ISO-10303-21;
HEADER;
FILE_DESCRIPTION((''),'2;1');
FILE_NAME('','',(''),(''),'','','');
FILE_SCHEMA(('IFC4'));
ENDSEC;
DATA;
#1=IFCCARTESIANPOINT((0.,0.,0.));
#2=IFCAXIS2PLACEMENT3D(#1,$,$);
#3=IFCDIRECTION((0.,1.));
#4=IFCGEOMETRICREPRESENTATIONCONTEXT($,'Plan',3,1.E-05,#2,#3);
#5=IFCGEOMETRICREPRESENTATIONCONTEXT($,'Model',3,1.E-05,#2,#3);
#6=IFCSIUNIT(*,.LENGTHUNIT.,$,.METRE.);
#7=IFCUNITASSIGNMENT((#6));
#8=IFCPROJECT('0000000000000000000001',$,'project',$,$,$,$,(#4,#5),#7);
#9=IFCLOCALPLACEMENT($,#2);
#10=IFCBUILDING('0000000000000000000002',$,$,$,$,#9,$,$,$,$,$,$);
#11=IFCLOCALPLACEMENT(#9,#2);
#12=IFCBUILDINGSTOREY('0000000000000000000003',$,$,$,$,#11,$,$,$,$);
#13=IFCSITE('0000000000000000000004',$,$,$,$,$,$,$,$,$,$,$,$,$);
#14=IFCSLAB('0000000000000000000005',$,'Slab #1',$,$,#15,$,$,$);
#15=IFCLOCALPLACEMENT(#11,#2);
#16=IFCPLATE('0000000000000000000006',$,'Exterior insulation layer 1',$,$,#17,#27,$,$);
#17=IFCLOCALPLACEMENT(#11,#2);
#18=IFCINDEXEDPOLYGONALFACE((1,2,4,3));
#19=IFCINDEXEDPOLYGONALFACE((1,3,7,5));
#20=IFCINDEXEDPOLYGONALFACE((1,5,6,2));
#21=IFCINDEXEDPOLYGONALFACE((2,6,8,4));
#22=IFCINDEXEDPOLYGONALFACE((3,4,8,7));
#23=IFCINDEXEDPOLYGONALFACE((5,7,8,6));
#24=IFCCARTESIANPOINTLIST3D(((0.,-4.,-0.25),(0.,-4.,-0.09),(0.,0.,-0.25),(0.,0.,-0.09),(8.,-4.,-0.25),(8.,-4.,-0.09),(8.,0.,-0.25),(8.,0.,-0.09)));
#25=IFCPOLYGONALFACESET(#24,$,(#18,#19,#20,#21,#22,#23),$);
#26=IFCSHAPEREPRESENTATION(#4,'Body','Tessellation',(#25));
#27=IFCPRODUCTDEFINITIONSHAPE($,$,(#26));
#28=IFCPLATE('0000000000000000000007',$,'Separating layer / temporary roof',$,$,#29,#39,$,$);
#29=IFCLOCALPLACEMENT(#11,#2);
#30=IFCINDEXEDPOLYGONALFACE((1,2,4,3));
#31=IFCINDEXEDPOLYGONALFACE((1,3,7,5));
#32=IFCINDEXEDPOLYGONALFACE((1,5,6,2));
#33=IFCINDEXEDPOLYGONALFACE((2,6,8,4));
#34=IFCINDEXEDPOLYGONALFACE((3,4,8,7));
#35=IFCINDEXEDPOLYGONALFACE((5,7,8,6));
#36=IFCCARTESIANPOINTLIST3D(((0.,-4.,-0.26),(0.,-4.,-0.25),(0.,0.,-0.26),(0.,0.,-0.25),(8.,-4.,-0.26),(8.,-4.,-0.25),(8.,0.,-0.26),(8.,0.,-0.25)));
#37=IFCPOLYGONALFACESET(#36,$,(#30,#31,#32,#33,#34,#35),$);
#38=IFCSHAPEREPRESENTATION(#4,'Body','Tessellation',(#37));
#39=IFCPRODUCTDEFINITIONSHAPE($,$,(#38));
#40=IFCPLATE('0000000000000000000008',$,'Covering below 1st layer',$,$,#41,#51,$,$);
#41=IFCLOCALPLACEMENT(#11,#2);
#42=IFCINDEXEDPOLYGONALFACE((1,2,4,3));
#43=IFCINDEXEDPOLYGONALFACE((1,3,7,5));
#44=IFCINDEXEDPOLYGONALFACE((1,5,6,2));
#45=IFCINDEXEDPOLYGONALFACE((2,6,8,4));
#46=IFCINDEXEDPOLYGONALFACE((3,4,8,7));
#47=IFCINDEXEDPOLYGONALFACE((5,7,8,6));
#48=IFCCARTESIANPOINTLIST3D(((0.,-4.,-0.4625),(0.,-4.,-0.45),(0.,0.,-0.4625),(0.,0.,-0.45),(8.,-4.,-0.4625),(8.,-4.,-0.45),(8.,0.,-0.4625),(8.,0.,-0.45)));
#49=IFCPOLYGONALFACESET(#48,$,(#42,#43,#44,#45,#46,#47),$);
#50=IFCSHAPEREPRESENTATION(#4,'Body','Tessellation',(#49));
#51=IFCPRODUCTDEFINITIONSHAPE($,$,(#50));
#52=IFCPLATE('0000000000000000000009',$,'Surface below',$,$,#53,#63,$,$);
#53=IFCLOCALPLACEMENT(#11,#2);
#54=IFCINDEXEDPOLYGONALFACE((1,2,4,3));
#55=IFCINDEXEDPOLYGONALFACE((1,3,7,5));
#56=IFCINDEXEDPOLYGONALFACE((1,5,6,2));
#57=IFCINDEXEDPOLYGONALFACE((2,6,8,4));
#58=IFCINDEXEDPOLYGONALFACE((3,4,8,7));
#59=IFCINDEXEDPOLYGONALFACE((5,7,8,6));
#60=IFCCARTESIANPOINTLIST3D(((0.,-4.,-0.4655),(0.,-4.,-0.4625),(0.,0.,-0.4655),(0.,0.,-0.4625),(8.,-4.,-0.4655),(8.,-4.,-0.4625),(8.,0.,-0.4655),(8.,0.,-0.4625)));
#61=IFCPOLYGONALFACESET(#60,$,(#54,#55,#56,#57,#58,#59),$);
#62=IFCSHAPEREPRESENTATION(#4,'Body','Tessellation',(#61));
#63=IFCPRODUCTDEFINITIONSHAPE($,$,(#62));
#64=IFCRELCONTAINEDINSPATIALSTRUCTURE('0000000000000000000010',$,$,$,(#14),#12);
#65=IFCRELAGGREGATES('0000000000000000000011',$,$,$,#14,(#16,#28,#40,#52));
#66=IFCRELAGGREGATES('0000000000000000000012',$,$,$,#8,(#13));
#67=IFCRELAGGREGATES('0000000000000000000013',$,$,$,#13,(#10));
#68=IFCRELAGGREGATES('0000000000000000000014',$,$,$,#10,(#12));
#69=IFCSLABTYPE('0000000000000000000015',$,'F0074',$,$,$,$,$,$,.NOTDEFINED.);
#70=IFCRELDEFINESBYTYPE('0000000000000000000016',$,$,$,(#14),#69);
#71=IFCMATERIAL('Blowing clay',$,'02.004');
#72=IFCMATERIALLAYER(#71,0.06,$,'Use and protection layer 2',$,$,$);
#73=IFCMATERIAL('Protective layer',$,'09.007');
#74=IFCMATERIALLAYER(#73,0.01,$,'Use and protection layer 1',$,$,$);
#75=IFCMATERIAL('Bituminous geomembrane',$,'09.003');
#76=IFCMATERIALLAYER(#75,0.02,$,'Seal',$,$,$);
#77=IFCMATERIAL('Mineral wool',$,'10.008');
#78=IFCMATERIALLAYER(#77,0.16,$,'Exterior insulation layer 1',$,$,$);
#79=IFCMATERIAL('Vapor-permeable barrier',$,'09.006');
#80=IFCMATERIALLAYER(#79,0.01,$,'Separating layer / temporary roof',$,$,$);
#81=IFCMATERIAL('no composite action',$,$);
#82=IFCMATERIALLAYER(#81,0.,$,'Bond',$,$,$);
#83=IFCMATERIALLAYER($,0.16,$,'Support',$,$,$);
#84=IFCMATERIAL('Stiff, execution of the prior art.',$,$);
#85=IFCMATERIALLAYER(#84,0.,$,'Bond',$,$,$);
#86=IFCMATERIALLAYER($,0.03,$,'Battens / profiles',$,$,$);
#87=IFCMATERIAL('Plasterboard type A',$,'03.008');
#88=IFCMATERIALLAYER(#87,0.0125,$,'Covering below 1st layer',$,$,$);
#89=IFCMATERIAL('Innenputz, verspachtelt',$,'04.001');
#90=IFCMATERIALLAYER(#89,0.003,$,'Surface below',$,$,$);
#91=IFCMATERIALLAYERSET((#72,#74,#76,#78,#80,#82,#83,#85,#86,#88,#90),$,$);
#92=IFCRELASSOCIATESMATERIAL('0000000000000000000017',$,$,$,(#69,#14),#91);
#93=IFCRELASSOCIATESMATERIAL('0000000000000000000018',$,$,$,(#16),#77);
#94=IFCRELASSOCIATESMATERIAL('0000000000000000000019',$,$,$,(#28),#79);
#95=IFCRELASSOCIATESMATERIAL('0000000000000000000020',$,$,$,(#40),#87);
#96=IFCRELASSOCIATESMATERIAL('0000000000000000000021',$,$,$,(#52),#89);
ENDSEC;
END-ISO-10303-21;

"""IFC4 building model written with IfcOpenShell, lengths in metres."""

from ifc_helpers import new_model, si_unit, direction, frame, frame_2d, origin, place, context, project, spatial, rectangle, extrude, material, layer, layer_set, type_object, element, aggregate, save


model = new_model("IFC4")

# Units and contexts
plan_context = context("Plan", 3, precision=1e-05, world=origin(), true_north=direction((0.0, 1.0)))
model_context = context("Model", 3, precision=1e-05, world=origin(), true_north=direction((0.0, 1.0)))
ifc_project = project(units=[si_unit("LENGTHUNIT", "METRE")], contexts=[plan_context, model_context])

# Site, building, storey
site = spatial("IfcSite", under=ifc_project)
building_placement = place(None, origin())
building = spatial("IfcBuilding", under=site, at=building_placement)
storey_placement = place(building_placement, origin())
storey = spatial("IfcBuildingStorey", under=building, at=storey_placement)

# Slab, plates
ifc_material_1 = material(Name="Blowing clay", Category="02.004")
ifc_layer_1 = layer(ifc_material_1, 0.06, Name="Use and protection layer 2")
ifc_material_2 = material(Name="Protective layer", Category="09.007")
ifc_layer_2 = layer(ifc_material_2, 0.01, Name="Use and protection layer 1")
ifc_material_3 = material(Name="Bituminous geomembrane", Category="09.003")
ifc_layer_3 = layer(ifc_material_3, 0.02, Name="Seal")
ifc_material_4 = material(Name="Mineral wool", Category="10.008")
ifc_layer_4 = layer(ifc_material_4, 0.16, Name="Exterior insulation layer 1")
ifc_material_5 = material(Name="Vapor-permeable barrier", Category="09.006")
ifc_layer_5 = layer(ifc_material_5, 0.01, Name="Separating layer / temporary roof")
ifc_material_6 = material(Name="no composite action")
ifc_layer_6 = layer(ifc_material_6, 0.0, Name="Bond")
ifc_layer_7 = layer(None, 0.16, Name="Support")
ifc_material_7 = material(Name="Stiff, execution of the prior art.")
ifc_layer_8 = layer(ifc_material_7, 0.0, Name="Bond")
ifc_layer_9 = layer(None, 0.03, Name="Battens / profiles")
ifc_material_8 = material(Name="Plasterboard type A", Category="03.008")
ifc_layer_10 = layer(ifc_material_8, 0.0125, Name="Covering below 1st layer")
ifc_material_9 = material(Name="Innenputz, verspachtelt", Category="04.001")
ifc_layer_11 = layer(ifc_material_9, 0.003, Name="Surface below")
ifc_layer_set = layer_set([ifc_layer_1, ifc_layer_2, ifc_layer_3, ifc_layer_4, ifc_layer_5, ifc_layer_6, ifc_layer_7, ifc_layer_8, ifc_layer_9, ifc_layer_10, ifc_layer_11])
slab_type = type_object("IfcSlabType", Name="F0074", PredefinedType="NOTDEFINED", material=ifc_layer_set)
slab_placement = place(None, frame((0.0, 0.0, 0.0), z_axis=(0.0, 0.0, -1.0), x_axis=(1.0, 0.0, 0.0)))
slab = element("IfcSlab", 1, at=slab_placement, inside=storey, type_object=slab_type, material=ifc_layer_set, Name="Slab #1")
plate_1_placement = place(slab_placement, origin())
plate_1 = element("IfcPlate", 2, at=plate_1_placement, material=ifc_material_4, Name="Exterior insulation layer 1", context=plan_context, shape_type="SweptSolid", body=[
    extrude(rectangle(XDim=8.0, YDim=4.0, at=frame_2d((4.0, 2.0), x_axis=(1.0, 0.0))), frame((0.0, 0.0, 0.09), z_axis=(0.0, 0.0, 1.0), x_axis=(1.0, 0.0, 0.0)), (0.0, 0.0, 1.0), 0.16),
])
plate_2_placement = place(slab_placement, origin())
plate_2 = element("IfcPlate", 3, at=plate_2_placement, material=ifc_material_5, Name="Separating layer / temporary roof", context=plan_context, shape_type="SweptSolid", body=[
    extrude(rectangle(XDim=8.0, YDim=4.0, at=frame_2d((4.0, 2.0), x_axis=(1.0, 0.0))), frame((0.0, 0.0, 0.25), z_axis=(0.0, 0.0, 1.0), x_axis=(1.0, 0.0, 0.0)), (0.0, 0.0, 1.0), 0.01),
])
plate_3_placement = place(slab_placement, origin())
plate_3 = element("IfcPlate", 4, at=plate_3_placement, material=ifc_material_8, Name="Covering below 1st layer", context=plan_context, shape_type="SweptSolid", body=[
    extrude(rectangle(XDim=8.0, YDim=4.0, at=frame_2d((4.0, 2.0), x_axis=(1.0, 0.0))), frame((0.0, 0.0, 0.45), z_axis=(0.0, 0.0, 1.0), x_axis=(1.0, 0.0, 0.0)), (0.0, 0.0, 1.0), 0.0125),
])
plate_4_placement = place(slab_placement, origin())
plate_4 = element("IfcPlate", 5, at=plate_4_placement, material=ifc_material_9, Name="Surface below", context=plan_context, shape_type="SweptSolid", body=[
    extrude(rectangle(XDim=8.0, YDim=4.0, at=frame_2d((4.0, 2.0), x_axis=(1.0, 0.0))), frame((0.0, 0.0, 0.4625), z_axis=(0.0, 0.0, 1.0), x_axis=(1.0, 0.0, 0.0)), (0.0, 0.0, 1.0), 0.003),
])
aggregate(slab, [plate_1, plate_2, plate_3, plate_4])

save(model, "model.ifc")
